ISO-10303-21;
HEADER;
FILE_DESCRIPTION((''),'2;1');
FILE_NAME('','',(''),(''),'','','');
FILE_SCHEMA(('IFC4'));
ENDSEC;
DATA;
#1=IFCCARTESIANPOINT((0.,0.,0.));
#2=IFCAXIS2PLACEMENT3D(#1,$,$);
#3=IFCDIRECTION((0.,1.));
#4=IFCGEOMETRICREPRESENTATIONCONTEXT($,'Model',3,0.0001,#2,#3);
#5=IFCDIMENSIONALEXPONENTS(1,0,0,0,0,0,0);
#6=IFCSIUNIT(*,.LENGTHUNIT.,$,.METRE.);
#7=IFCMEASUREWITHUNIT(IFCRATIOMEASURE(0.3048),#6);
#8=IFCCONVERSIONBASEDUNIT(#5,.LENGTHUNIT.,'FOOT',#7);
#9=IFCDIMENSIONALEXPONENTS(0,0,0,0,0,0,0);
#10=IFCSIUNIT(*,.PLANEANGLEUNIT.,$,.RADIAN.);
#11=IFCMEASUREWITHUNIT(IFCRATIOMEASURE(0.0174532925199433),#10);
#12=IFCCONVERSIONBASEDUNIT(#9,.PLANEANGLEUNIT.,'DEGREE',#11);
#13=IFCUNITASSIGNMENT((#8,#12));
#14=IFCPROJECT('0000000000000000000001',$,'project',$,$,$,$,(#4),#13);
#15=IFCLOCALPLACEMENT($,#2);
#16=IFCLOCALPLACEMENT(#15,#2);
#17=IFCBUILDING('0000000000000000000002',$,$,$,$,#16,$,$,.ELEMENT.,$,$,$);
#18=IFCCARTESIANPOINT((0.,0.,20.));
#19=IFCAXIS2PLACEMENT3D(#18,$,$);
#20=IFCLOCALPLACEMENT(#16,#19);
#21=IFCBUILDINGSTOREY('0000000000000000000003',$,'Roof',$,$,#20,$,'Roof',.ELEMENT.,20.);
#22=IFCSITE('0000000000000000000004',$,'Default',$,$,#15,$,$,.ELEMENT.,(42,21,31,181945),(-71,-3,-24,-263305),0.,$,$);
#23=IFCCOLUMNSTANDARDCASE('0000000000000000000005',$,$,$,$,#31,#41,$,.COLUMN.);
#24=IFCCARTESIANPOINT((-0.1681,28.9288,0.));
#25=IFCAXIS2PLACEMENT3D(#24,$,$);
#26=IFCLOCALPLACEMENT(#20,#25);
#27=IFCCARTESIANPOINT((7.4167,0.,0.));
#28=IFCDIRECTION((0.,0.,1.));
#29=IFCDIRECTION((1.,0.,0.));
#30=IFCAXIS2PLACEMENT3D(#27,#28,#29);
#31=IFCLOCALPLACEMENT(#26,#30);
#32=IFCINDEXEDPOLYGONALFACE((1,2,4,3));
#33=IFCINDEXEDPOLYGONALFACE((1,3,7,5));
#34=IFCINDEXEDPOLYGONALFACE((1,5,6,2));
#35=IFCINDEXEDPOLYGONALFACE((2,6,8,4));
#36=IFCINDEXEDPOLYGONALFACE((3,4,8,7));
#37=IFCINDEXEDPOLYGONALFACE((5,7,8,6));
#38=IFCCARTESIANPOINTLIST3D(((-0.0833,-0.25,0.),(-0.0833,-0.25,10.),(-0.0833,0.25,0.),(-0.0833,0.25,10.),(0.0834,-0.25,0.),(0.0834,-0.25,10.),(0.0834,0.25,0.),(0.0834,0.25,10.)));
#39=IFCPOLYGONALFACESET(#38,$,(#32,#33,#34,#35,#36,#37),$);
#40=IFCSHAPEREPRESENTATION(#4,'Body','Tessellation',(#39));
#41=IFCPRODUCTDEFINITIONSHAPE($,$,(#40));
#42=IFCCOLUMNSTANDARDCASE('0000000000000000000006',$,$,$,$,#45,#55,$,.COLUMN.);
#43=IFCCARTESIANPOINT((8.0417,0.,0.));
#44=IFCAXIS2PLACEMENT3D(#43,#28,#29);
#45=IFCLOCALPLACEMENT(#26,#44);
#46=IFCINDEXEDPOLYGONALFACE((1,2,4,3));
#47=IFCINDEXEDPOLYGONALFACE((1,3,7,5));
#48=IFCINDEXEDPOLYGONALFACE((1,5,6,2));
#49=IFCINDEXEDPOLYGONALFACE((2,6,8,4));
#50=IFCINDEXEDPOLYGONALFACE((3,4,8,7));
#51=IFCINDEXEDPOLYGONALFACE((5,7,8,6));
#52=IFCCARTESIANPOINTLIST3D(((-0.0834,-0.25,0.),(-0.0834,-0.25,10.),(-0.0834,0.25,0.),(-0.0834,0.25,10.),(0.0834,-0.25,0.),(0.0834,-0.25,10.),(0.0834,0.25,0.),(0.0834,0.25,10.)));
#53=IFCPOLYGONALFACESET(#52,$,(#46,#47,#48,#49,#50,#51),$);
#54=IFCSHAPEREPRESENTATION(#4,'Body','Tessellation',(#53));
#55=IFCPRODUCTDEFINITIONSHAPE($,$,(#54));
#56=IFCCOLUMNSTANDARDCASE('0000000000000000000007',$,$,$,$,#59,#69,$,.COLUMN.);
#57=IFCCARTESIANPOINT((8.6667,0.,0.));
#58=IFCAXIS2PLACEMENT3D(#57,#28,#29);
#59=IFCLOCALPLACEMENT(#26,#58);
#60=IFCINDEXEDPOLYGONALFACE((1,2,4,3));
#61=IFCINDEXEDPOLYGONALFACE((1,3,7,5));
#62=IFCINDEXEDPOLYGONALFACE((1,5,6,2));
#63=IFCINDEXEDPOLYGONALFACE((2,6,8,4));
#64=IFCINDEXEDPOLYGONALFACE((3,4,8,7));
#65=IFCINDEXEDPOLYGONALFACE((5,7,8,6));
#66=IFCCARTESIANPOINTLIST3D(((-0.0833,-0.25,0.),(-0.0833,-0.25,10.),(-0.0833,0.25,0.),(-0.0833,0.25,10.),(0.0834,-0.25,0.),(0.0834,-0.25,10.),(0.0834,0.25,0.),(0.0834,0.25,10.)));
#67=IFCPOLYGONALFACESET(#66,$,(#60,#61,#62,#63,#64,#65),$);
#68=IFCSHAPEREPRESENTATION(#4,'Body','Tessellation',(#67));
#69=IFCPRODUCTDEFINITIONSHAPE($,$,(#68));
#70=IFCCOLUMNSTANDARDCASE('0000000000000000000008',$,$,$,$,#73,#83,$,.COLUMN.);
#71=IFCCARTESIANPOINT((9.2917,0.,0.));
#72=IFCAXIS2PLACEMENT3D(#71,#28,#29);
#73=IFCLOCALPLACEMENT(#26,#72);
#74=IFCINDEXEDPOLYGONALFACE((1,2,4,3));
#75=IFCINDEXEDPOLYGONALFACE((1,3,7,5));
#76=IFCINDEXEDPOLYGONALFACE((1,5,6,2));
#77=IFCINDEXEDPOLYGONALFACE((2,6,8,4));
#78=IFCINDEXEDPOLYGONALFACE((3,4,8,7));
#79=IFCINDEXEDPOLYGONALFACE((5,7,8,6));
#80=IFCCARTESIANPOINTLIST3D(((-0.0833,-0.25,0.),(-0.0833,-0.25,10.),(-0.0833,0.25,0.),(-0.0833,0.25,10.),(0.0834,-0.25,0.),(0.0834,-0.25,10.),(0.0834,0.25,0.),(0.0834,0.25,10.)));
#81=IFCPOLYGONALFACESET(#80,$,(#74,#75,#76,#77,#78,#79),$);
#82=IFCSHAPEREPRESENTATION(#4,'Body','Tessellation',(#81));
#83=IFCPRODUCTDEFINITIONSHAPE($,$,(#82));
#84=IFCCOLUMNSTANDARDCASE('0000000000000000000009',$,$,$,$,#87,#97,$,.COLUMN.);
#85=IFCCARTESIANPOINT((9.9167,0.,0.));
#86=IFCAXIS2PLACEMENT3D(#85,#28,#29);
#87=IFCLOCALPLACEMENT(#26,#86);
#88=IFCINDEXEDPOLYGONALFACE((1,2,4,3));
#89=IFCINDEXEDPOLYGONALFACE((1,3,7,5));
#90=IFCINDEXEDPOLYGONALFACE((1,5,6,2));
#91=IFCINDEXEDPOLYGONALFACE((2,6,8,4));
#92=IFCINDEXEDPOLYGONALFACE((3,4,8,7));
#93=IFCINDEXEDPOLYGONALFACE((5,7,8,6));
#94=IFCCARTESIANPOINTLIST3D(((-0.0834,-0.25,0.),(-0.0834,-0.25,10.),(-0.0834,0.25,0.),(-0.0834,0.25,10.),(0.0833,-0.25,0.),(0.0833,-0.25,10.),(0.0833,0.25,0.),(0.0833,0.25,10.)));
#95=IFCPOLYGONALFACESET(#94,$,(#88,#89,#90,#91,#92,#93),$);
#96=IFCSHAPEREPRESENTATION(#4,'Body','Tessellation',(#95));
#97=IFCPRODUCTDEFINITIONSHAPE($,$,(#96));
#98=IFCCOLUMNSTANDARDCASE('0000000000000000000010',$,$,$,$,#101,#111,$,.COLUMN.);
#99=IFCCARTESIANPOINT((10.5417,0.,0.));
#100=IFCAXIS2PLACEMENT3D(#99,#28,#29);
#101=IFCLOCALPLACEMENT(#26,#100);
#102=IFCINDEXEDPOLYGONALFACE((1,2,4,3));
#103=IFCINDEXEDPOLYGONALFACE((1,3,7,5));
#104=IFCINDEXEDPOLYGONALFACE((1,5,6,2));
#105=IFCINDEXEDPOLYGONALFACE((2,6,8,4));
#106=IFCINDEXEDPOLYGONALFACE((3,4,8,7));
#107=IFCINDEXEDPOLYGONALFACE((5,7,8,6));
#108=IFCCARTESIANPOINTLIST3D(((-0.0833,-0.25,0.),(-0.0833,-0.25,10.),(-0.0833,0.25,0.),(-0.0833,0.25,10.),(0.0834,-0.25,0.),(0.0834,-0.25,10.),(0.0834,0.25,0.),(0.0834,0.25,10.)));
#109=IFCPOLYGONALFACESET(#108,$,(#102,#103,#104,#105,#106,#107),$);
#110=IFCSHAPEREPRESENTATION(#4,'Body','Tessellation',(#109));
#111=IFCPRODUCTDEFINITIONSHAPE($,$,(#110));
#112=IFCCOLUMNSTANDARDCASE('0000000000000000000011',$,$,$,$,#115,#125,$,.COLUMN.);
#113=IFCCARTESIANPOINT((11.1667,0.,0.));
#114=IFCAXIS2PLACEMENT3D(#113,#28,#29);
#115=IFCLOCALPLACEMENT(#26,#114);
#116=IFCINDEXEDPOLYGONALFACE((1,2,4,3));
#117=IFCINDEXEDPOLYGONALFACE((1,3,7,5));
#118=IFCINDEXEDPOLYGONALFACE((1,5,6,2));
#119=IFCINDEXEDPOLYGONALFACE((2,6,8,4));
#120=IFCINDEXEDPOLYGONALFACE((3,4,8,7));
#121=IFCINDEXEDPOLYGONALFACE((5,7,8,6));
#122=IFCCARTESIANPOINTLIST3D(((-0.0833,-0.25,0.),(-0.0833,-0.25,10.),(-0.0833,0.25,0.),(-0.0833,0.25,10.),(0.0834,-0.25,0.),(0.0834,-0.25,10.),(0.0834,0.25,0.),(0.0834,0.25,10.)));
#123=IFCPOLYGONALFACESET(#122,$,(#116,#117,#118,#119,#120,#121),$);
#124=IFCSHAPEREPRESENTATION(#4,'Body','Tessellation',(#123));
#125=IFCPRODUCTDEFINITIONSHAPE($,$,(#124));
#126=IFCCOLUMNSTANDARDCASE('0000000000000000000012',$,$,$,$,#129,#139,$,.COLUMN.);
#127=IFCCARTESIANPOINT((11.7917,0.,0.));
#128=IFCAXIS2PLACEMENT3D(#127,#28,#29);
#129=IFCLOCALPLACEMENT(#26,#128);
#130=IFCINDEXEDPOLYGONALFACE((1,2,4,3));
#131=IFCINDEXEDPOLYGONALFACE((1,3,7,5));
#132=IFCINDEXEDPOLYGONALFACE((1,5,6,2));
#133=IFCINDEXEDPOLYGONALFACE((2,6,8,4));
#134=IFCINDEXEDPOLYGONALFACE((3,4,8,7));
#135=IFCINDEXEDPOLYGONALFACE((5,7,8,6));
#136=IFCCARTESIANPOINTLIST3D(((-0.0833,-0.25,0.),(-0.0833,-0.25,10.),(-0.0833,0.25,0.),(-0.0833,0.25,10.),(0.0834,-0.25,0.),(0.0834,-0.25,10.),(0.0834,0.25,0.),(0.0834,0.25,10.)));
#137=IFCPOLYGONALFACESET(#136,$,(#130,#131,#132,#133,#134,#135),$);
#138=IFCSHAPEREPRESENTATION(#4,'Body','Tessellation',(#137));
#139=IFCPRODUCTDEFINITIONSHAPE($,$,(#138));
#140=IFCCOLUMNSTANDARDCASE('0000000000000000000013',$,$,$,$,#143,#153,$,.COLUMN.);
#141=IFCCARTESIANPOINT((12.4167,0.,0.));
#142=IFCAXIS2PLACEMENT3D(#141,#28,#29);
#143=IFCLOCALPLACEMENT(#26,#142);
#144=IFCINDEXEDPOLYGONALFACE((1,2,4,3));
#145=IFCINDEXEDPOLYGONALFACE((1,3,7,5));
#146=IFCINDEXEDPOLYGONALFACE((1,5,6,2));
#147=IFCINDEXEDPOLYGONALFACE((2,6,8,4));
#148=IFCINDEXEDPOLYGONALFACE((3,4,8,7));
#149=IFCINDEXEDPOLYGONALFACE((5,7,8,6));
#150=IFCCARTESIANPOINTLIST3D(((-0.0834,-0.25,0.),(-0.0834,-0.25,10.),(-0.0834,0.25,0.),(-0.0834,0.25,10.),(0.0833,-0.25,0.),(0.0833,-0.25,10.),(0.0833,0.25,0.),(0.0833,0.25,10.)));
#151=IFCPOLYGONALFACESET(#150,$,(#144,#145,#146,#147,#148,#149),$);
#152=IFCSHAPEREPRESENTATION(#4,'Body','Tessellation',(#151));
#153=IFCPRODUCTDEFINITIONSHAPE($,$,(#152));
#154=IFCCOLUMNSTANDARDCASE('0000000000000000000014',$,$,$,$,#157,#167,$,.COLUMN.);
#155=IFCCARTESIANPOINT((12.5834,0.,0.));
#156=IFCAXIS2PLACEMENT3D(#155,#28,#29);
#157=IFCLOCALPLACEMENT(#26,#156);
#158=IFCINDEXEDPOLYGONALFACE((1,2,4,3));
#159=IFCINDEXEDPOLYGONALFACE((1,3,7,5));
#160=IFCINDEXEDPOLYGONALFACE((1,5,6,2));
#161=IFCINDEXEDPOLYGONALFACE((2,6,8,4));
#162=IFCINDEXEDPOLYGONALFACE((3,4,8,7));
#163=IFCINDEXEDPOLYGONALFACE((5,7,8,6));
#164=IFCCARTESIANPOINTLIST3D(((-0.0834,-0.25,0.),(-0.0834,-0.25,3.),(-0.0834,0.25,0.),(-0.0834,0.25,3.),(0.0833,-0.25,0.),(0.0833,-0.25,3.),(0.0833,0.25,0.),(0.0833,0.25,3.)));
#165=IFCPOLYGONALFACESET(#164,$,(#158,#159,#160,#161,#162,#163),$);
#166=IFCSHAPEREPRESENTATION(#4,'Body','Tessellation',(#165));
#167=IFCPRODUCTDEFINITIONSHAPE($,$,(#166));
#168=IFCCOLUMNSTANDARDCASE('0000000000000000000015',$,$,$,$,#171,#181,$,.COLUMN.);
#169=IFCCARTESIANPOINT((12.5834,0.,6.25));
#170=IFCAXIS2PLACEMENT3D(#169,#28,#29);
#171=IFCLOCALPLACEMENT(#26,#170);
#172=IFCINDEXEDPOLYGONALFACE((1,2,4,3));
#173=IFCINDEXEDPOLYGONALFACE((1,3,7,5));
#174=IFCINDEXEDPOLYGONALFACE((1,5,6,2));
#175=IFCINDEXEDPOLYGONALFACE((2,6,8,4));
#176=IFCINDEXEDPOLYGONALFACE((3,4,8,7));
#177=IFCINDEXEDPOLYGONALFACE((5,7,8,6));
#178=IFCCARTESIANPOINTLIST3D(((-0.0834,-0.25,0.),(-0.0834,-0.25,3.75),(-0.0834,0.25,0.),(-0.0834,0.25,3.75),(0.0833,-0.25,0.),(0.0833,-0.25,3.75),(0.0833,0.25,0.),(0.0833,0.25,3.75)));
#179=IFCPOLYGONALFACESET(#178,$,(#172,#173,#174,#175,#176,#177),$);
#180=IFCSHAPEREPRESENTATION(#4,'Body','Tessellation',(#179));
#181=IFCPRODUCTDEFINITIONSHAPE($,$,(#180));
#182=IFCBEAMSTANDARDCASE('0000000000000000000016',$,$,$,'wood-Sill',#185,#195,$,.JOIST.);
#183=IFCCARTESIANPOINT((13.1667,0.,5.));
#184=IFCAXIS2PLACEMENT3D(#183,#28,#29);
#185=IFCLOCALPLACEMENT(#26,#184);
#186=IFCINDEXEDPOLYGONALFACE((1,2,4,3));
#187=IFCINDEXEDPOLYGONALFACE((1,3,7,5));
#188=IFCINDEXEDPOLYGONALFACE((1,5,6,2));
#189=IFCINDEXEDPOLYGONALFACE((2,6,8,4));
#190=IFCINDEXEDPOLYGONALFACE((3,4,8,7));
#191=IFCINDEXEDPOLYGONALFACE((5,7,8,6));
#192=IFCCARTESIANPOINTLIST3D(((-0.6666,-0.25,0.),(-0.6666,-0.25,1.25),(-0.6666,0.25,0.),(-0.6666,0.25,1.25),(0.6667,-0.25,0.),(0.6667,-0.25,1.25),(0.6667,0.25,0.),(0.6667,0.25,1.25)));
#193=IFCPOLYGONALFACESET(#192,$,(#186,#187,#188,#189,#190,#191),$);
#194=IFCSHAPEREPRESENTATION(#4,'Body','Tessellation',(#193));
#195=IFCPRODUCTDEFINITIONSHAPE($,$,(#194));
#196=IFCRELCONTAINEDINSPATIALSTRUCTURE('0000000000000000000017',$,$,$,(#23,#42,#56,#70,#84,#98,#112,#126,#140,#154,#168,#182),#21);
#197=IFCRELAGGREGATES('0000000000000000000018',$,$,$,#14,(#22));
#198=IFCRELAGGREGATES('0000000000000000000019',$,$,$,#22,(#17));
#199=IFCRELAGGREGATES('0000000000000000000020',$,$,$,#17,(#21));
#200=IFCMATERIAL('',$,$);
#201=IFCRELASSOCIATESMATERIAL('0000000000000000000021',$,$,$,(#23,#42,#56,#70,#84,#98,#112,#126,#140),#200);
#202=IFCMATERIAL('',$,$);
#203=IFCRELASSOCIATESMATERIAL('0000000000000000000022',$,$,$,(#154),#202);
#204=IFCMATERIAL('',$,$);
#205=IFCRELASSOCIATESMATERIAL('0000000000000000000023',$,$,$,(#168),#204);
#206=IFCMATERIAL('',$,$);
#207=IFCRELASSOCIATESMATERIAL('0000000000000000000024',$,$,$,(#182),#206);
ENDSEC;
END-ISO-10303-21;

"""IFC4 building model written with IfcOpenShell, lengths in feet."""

from ifc_helpers import new_model, entity, si_unit, converted_unit, direction, frame, origin, place, context, project, spatial, rectangle, extrude, material, element, save


model = new_model("IFC4")

# Units and contexts
model_context = context("Model", 3, precision=0.0001, world=origin(), true_north=direction((0.0, 1.0)))
ifc_project = project(units=[converted_unit("LENGTHUNIT", "FOOT", entity("IfcRatioMeasure", 0.3048), si_unit("LENGTHUNIT", "METRE"), dimensions=[1, 0, 0, 0, 0, 0, 0]), converted_unit("PLANEANGLEUNIT", "DEGREE", entity("IfcRatioMeasure", 0.0174532925199433), si_unit("PLANEANGLEUNIT", "RADIAN"), dimensions=[0, 0, 0, 0, 0, 0, 0])], contexts=[model_context])

# Site, building, storey
site_placement = place(None, origin())
site = spatial("IfcSite", under=ifc_project, at=site_placement, Name="Default", CompositionType="ELEMENT", RefLatitude=(42, 21, 31, 181945), RefLongitude=(-71, -3, -24, -263305), RefElevation=0.0)
building_placement = place(site_placement, origin())
building = spatial("IfcBuilding", under=site, at=building_placement, CompositionType="ELEMENT")
storey_placement = place(building_placement, frame((0.0, 0.0, 20.0)))
storey = spatial("IfcBuildingStorey", under=building, at=storey_placement, Name="Roof", LongName="Roof", CompositionType="ELEMENT", Elevation=20.0)

# Columns
ifc_material_1 = material(Name="")
placement = place(storey_placement, frame((-0.1681, 28.9288, 0.0)))
for number, where, z_axis, x_axis in (
    (1, (7.4167, 0.0, 0.0), (0.0, 0.0, 1.0), (1.0, 0.0, 0.0)),
    (2, (8.0417, 0.0, 0.0), (0.0, 0.0, 1.0), (1.0, 0.0, 0.0)),
    (3, (8.6667, 0.0, 0.0), (0.0, 0.0, 1.0), (1.0, 0.0, 0.0)),
    (4, (9.2917, 0.0, 0.0), (0.0, 0.0, 1.0), (1.0, 0.0, 0.0)),
    (5, (9.9167, 0.0, 0.0), (0.0, 0.0, 1.0), (1.0, 0.0, 0.0)),
    (6, (10.5417, 0.0, 0.0), (0.0, 0.0, 1.0), (1.0, 0.0, 0.0)),
    (7, (11.1667, 0.0, 0.0), (0.0, 0.0, 1.0), (1.0, 0.0, 0.0)),
    (8, (11.7917, 0.0, 0.0), (0.0, 0.0, 1.0), (1.0, 0.0, 0.0)),
    (9, (12.4167, 0.0, 0.0), (0.0, 0.0, 1.0), (1.0, 0.0, 0.0)),
):
    element("IfcColumnStandardCase", number, at=place(placement, frame(where, z_axis=z_axis, x_axis=x_axis)), inside=storey, material=ifc_material_1, PredefinedType="COLUMN", context=model_context, shape_type="SweptSolid", body=[
        extrude(rectangle(XDim=0.1667, YDim=0.5), origin(), (0.0, 0.0, 1.0), 10.0),
    ])
ifc_material_2 = material(Name="")
for number, where, z_axis, x_axis in (
    (10, (12.5834, 0.0, 0.0), (0.0, 0.0, 1.0), (1.0, 0.0, 0.0)),
):
    element("IfcColumnStandardCase", number, at=place(placement, frame(where, z_axis=z_axis, x_axis=x_axis)), inside=storey, material=ifc_material_2, PredefinedType="COLUMN", context=model_context, shape_type="SweptSolid", body=[
        extrude(rectangle(XDim=0.1667, YDim=0.5), origin(), (0.0, 0.0, 1.0), 3.0),
    ])
ifc_material_3 = material(Name="")
for number, where, z_axis, x_axis in (
    (11, (12.5834, 0.0, 6.25), (0.0, 0.0, 1.0), (1.0, 0.0, 0.0)),
):
    element("IfcColumnStandardCase", number, at=place(placement, frame(where, z_axis=z_axis, x_axis=x_axis)), inside=storey, material=ifc_material_3, PredefinedType="COLUMN", context=model_context, shape_type="SweptSolid", body=[
        extrude(rectangle(XDim=0.1667, YDim=0.5), origin(), (0.0, 0.0, 1.0), 3.75),
    ])

# Beam
ifc_material_4 = material(Name="")
for number, where, z_axis, x_axis in (
    (12, (13.1667, 0.0, 5.0), (0.0, 0.0, 1.0), (1.0, 0.0, 0.0)),
):
    element("IfcBeamStandardCase", number, at=place(placement, frame(where, z_axis=z_axis, x_axis=x_axis)), inside=storey, material=ifc_material_4, ObjectType="wood-Sill", PredefinedType="JOIST", context=model_context, shape_type="SweptSolid", body=[
        extrude(rectangle(XDim=1.3333, YDim=0.5), origin(), (0.0, 0.0, 1.0), 1.25),
    ])

save(model, "model.ifc")
